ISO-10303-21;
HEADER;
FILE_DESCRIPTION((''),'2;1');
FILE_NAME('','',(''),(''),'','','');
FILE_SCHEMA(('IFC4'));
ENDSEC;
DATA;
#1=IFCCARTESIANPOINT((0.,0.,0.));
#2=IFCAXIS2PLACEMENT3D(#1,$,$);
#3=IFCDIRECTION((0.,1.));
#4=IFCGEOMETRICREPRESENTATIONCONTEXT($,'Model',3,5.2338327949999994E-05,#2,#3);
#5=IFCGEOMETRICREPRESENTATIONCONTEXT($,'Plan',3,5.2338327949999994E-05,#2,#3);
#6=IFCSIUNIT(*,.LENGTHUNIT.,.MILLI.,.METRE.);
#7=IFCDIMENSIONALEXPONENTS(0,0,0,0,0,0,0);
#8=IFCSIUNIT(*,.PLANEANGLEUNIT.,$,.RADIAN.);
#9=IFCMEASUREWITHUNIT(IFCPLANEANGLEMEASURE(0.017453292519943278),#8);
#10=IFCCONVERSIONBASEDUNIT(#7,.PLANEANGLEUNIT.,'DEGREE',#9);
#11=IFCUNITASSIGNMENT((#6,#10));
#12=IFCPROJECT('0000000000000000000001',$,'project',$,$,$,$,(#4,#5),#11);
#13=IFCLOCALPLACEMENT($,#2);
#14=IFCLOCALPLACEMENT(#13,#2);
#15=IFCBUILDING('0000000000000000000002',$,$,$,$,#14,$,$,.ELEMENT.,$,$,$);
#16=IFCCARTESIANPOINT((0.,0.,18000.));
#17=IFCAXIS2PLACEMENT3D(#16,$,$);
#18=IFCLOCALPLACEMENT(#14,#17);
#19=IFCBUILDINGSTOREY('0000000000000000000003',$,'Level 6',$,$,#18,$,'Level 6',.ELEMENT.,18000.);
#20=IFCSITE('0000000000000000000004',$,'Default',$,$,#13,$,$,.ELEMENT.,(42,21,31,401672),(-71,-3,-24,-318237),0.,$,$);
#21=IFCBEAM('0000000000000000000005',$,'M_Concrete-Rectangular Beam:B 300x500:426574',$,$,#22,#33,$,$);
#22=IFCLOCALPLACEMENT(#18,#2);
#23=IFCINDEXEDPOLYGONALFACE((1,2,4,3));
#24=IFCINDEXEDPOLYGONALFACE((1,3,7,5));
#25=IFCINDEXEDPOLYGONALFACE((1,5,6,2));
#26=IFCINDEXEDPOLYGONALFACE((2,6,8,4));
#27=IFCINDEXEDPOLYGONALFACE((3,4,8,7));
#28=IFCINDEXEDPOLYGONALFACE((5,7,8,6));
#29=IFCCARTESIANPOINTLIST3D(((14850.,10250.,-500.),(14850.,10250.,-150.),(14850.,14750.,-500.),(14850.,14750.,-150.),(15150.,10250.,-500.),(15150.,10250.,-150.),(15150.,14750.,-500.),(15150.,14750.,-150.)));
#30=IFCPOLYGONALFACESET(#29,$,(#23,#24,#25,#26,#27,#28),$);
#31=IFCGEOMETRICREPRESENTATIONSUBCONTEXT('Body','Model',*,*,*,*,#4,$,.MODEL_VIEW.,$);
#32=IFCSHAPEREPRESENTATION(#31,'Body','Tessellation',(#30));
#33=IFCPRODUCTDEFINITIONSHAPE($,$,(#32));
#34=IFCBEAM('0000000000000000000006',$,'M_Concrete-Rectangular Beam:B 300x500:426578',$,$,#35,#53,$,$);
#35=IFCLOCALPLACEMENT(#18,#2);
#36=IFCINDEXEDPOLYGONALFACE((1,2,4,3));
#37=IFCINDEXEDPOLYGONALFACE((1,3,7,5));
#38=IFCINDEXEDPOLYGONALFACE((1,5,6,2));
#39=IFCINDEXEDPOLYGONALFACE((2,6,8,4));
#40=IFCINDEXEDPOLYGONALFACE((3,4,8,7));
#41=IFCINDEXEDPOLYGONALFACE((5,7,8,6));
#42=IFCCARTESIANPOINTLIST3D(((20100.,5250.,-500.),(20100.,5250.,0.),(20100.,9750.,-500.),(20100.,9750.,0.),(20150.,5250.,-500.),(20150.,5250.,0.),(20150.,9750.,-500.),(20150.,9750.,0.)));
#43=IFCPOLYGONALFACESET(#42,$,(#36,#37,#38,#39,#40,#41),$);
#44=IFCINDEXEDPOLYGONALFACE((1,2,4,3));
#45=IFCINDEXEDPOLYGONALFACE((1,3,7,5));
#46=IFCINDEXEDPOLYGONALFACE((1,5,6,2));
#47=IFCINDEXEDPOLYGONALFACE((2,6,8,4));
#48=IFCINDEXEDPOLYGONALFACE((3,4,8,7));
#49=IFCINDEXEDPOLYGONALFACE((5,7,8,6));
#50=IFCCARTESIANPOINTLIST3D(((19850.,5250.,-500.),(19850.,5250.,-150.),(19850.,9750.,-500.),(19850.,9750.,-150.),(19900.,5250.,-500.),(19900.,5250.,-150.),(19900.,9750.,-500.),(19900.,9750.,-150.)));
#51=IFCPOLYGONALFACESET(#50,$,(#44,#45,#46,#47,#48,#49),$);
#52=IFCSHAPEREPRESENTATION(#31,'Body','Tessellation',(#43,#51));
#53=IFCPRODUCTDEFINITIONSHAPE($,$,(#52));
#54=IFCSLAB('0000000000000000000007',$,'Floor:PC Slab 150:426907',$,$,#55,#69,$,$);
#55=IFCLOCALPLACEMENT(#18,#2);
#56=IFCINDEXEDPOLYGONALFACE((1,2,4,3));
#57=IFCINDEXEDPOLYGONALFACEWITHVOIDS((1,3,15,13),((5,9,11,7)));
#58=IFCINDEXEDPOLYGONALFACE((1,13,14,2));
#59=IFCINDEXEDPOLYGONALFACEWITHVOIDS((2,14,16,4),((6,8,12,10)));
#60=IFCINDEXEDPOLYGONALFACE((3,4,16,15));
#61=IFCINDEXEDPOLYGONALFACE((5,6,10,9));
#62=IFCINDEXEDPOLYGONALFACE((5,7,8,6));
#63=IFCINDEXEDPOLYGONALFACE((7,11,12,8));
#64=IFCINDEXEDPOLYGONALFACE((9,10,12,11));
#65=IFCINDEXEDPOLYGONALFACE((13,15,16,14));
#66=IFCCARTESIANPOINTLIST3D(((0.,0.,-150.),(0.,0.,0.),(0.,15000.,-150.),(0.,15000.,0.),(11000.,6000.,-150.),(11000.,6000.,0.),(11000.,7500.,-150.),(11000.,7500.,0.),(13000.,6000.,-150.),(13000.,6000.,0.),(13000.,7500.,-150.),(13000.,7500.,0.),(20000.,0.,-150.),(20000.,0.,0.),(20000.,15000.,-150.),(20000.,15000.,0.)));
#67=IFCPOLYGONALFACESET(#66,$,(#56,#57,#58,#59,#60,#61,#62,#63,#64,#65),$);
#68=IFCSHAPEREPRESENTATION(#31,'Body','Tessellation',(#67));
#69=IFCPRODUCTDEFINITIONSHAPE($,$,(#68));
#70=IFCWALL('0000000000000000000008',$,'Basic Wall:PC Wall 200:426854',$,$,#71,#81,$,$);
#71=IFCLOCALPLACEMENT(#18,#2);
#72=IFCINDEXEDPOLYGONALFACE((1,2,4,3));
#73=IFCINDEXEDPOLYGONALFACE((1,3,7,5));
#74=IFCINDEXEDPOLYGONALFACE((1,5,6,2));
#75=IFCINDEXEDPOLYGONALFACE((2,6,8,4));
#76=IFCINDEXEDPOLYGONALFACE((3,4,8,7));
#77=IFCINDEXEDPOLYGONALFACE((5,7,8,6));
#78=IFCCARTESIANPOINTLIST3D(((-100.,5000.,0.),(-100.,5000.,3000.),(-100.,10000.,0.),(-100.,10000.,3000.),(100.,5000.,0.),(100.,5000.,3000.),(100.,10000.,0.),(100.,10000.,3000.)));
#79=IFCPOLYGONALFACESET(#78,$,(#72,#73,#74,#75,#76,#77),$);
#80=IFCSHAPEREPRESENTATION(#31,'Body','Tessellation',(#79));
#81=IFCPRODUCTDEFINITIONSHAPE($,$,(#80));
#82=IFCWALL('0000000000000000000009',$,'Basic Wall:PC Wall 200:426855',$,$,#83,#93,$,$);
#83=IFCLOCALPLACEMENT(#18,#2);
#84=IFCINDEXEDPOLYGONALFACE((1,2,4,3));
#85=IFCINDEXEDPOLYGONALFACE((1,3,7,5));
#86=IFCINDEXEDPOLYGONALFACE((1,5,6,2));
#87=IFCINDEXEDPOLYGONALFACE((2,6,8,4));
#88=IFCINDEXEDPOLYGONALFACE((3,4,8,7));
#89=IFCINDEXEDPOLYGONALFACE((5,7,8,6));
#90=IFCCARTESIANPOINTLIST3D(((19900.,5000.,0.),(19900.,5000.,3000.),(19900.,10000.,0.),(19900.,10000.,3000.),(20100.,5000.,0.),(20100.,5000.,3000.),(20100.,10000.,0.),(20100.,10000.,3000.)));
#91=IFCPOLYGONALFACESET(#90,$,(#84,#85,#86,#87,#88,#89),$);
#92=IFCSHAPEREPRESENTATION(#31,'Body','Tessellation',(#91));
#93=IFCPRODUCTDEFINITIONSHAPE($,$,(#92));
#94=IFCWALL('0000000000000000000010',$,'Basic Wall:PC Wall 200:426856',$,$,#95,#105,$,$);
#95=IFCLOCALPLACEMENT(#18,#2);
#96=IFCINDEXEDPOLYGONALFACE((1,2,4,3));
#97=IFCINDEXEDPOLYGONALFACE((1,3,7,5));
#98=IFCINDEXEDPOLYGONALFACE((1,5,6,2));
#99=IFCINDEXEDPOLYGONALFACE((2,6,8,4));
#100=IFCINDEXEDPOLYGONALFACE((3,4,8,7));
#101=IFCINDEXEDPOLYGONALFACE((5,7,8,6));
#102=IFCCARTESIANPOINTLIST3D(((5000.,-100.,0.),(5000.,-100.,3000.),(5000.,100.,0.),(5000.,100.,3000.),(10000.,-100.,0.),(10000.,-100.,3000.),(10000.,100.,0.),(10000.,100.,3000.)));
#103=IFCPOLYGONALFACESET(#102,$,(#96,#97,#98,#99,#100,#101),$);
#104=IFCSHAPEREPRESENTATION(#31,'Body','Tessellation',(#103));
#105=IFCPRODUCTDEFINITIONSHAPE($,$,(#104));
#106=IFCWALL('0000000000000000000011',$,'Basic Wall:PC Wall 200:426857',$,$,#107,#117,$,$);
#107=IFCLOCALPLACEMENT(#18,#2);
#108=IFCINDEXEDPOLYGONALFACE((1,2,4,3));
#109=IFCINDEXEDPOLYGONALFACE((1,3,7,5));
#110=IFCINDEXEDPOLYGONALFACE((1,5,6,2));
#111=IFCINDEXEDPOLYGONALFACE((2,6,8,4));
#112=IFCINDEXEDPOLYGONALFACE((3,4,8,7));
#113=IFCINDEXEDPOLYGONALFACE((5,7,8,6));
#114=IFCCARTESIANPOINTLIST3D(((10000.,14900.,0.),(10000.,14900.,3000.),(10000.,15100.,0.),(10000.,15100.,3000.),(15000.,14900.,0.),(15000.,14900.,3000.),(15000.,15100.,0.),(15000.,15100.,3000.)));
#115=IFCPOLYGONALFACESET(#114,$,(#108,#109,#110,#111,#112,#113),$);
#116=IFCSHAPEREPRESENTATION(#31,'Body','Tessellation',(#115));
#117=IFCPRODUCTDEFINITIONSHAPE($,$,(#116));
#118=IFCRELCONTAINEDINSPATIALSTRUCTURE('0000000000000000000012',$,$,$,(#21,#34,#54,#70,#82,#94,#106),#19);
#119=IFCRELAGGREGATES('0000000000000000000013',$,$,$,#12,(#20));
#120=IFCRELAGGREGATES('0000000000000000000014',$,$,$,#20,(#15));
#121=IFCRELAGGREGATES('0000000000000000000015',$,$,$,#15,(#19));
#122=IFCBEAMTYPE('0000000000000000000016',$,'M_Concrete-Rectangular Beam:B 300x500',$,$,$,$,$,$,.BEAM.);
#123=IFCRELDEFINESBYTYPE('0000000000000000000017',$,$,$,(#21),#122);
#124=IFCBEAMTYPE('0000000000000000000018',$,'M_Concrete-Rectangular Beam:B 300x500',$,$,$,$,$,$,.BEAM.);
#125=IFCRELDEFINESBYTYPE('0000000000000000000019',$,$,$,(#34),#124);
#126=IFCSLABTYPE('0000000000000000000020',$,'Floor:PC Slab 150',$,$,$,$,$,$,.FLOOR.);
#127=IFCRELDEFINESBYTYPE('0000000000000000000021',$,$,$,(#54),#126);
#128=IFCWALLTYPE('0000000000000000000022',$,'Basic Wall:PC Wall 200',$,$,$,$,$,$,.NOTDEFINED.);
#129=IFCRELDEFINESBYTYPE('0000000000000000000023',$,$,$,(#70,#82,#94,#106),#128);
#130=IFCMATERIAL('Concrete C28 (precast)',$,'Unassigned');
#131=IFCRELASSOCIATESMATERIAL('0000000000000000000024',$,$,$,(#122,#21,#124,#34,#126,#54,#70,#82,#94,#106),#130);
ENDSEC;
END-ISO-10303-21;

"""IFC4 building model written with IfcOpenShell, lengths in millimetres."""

from ifc_helpers import new_model, entity, si_unit, converted_unit, direction, frame, origin, place, context, subcontext, project, spatial, indexed_curve, outline, extrude, source, transform, mapped, material, type_object, type_shapes, element, save


model = new_model("IFC4")

# Units and contexts
model_context = context("Model", 3, precision=5.2338327949999994e-05, world=origin(), true_north=direction((0.0, 1.0)))
plan_context = context("Plan", 3, precision=5.2338327949999994e-05, world=origin(), true_north=direction((0.0, 1.0)))
body_context = subcontext(model_context, "Body", "Model", "MODEL_VIEW")
ifc_project = project(units=[si_unit("LENGTHUNIT", "METRE", prefix="MILLI"), converted_unit("PLANEANGLEUNIT", "DEGREE", entity("IfcPlaneAngleMeasure", 0.017453292519943278), si_unit("PLANEANGLEUNIT", "RADIAN"), dimensions=[0, 0, 0, 0, 0, 0, 0])], contexts=[model_context, plan_context])

# Site, building, storey
site_placement = place(None, origin())
site = spatial("IfcSite", under=ifc_project, at=site_placement, Name="Default", CompositionType="ELEMENT", RefLatitude=(42, 21, 31, 401672), RefLongitude=(-71, -3, -24, -318237), RefElevation=0.0)
building_placement = place(site_placement, origin())
building = spatial("IfcBuilding", under=site, at=building_placement, CompositionType="ELEMENT")
storey_placement = place(building_placement, frame((0.0, 0.0, 18000.0)))
storey = spatial("IfcBuildingStorey", under=building, at=storey_placement, Name="Level 6", LongName="Level 6", CompositionType="ELEMENT", Elevation=18000.0)

# Beams
ifc_material = material(Name="Concrete C28 (precast)", Category="Unassigned")
beam_type_1 = type_object("IfcBeamType", Name="M_Concrete-Rectangular Beam:B 300x500", PredefinedType="BEAM", material=ifc_material)
shared_shape_1 = source(origin(), body_context, "Body", "SweptSolid", [
    extrude(outline(indexed_curve([(-150.0, -175.0), (150.0, -175.0), (150.0, 175.0), (-150.0, 175.0), (-150.0, -175.0)], self_intersect=False)), frame((15000.0, 10250.0, 17675.0), z_axis=(0.0, 1.0, 0.0), x_axis=(-1.0, 0.0, 0.0)), (0.0, 0.0, 1.0), 4500.0),
])
type_shapes(beam_type_1, [shared_shape_1])
beam_1_placement = place(storey_placement, frame((0.0, 0.0, -18000.0)))
element("IfcBeam", 1, at=beam_1_placement, inside=storey, type_object=beam_type_1, material=ifc_material, Name="M_Concrete-Rectangular Beam:B 300x500:426574", context=body_context, shape_type="MappedRepresentation", body=[
    mapped(shared_shape_1, transform((0.0, 0.0, 0.0), scale=1.0)),
])
beam_type_2 = type_object("IfcBeamType", Name="M_Concrete-Rectangular Beam:B 300x500", PredefinedType="BEAM", material=ifc_material)
shared_shape_2 = source(origin(), body_context, "Body", "SweptSolid", [
    extrude(outline(indexed_curve([(-25.0, -250.0), (25.0, -250.0), (25.0, 250.0), (-25.0, 250.0), (-25.0, -250.0)], self_intersect=False)), frame((20125.0, 5250.0, 17750.0), z_axis=(0.0, 1.0, 0.0), x_axis=(-1.0, 0.0, 0.0)), (0.0, 0.0, 1.0), 4500.0),
    extrude(outline(indexed_curve([(-25.0, -175.0), (25.0, -175.0), (25.0, 175.0), (-25.0, 175.0), (-25.0, -175.0)], self_intersect=False)), frame((19875.0, 5250.0, 17675.0), z_axis=(0.0, 1.0, 0.0), x_axis=(-1.0, 0.0, 0.0)), (0.0, 0.0, 1.0), 4500.0),
])
type_shapes(beam_type_2, [shared_shape_2])
beam_2_placement = place(storey_placement, frame((0.0, 0.0, -18000.0)))
element("IfcBeam", 2, at=beam_2_placement, inside=storey, type_object=beam_type_2, material=ifc_material, Name="M_Concrete-Rectangular Beam:B 300x500:426578", context=body_context, shape_type="MappedRepresentation", body=[
    mapped(shared_shape_2, transform((0.0, 0.0, 0.0), scale=1.0)),
])

# Slab, opening
slab_type = type_object("IfcSlabType", Name="Floor:PC Slab 150", PredefinedType="FLOOR", material=ifc_material)
slab_placement = place(storey_placement, origin())
slab = element("IfcSlab", 3, at=slab_placement, inside=storey, type_object=slab_type, material=ifc_material, Name="Floor:PC Slab 150:426907", context=body_context, shape_type="SweptSolid", body=[
    extrude(outline(indexed_curve([(-7500.0, -10000.0), (7500.0, -10000.0), (7500.0, 10000.0), (-7500.0, 10000.0), (-7500.0, -10000.0)], self_intersect=False), holes=[indexed_curve([(-1500.0, -3000.0), (-1500.0, -1000.0), (0.0, -1000.0), (0.0, -3000.0), (-1500.0, -3000.0)], self_intersect=False)]), frame((10000.0, 7500.0, -150.0), z_axis=(0.0, 0.0, 1.0), x_axis=(0.0, 1.0, 0.0)), (0.0, 0.0, 1.0), 150.0),
])
opening_placement = place(slab_placement, origin())
element("IfcOpeningElement", 4, at=opening_placement, cuts=slab, PredefinedType="OPENING", context=body_context, shape_type="SweptSolid", body=[
    extrude(outline(indexed_curve([(13000.0, 6000.0), (13000.0, 7500.0), (11000.0, 7500.0), (11000.0, 6000.0), (13000.0, 6000.0)], self_intersect=False)), frame((0.0, 0.0, -18000.0)), (0.0, 0.0, 1.0), 20000.0),
])

# Walls
wall_type = type_object("IfcWallType", Name="Basic Wall:PC Wall 200", PredefinedType="NOTDEFINED")
wall_1_placement = place(storey_placement, frame((0.0, 5000.0, 0.0), z_axis=(0.0, 0.0, 1.0), x_axis=(0.0, 1.0, 0.0)))
element("IfcWall", 5, at=wall_1_placement, inside=storey, type_object=wall_type, material=ifc_material, Name="Basic Wall:PC Wall 200:426854", context=body_context, shape_type="SweptSolid", body=[
    extrude(outline(indexed_curve([(5000.0, 100.0), (0.0, 100.0), (0.0, -100.0), (5000.0, -100.0), (5000.0, 100.0)], self_intersect=False)), origin(), (0.0, 0.0, 1.0), 3000.0),
])
wall_2_placement = place(storey_placement, frame((20000.0, 5000.0, 0.0), z_axis=(0.0, 0.0, 1.0), x_axis=(0.0, 1.0, 0.0)))
element("IfcWall", 6, at=wall_2_placement, inside=storey, type_object=wall_type, material=ifc_material, Name="Basic Wall:PC Wall 200:426855", context=body_context, shape_type="SweptSolid", body=[
    extrude(outline(indexed_curve([(5000.0, 100.0), (0.0, 100.0), (0.0, -100.0), (5000.0, -100.0), (5000.0, 100.0)], self_intersect=False)), origin(), (0.0, 0.0, 1.0), 3000.0),
])
wall_3_placement = place(storey_placement, frame((5000.0, 0.0, 0.0)))
element("IfcWall", 7, at=wall_3_placement, inside=storey, type_object=wall_type, material=ifc_material, Name="Basic Wall:PC Wall 200:426856", context=body_context, shape_type="SweptSolid", body=[
    extrude(outline(indexed_curve([(5000.0, 100.0), (0.0, 100.0), (0.0, -100.0), (5000.0, -100.0), (5000.0, 100.0)], self_intersect=False)), origin(), (0.0, 0.0, 1.0), 3000.0),
])
wall_4_placement = place(storey_placement, frame((10000.0, 15000.0, 0.0)))
element("IfcWall", 8, at=wall_4_placement, inside=storey, type_object=wall_type, material=ifc_material, Name="Basic Wall:PC Wall 200:426857", context=body_context, shape_type="SweptSolid", body=[
    extrude(outline(indexed_curve([(5000.0, 100.0), (0.0, 100.0), (0.0, -100.0), (5000.0, -100.0), (5000.0, 100.0)], self_intersect=False)), origin(), (0.0, 0.0, 1.0), 3000.0),
])

save(model, "model.ifc")
